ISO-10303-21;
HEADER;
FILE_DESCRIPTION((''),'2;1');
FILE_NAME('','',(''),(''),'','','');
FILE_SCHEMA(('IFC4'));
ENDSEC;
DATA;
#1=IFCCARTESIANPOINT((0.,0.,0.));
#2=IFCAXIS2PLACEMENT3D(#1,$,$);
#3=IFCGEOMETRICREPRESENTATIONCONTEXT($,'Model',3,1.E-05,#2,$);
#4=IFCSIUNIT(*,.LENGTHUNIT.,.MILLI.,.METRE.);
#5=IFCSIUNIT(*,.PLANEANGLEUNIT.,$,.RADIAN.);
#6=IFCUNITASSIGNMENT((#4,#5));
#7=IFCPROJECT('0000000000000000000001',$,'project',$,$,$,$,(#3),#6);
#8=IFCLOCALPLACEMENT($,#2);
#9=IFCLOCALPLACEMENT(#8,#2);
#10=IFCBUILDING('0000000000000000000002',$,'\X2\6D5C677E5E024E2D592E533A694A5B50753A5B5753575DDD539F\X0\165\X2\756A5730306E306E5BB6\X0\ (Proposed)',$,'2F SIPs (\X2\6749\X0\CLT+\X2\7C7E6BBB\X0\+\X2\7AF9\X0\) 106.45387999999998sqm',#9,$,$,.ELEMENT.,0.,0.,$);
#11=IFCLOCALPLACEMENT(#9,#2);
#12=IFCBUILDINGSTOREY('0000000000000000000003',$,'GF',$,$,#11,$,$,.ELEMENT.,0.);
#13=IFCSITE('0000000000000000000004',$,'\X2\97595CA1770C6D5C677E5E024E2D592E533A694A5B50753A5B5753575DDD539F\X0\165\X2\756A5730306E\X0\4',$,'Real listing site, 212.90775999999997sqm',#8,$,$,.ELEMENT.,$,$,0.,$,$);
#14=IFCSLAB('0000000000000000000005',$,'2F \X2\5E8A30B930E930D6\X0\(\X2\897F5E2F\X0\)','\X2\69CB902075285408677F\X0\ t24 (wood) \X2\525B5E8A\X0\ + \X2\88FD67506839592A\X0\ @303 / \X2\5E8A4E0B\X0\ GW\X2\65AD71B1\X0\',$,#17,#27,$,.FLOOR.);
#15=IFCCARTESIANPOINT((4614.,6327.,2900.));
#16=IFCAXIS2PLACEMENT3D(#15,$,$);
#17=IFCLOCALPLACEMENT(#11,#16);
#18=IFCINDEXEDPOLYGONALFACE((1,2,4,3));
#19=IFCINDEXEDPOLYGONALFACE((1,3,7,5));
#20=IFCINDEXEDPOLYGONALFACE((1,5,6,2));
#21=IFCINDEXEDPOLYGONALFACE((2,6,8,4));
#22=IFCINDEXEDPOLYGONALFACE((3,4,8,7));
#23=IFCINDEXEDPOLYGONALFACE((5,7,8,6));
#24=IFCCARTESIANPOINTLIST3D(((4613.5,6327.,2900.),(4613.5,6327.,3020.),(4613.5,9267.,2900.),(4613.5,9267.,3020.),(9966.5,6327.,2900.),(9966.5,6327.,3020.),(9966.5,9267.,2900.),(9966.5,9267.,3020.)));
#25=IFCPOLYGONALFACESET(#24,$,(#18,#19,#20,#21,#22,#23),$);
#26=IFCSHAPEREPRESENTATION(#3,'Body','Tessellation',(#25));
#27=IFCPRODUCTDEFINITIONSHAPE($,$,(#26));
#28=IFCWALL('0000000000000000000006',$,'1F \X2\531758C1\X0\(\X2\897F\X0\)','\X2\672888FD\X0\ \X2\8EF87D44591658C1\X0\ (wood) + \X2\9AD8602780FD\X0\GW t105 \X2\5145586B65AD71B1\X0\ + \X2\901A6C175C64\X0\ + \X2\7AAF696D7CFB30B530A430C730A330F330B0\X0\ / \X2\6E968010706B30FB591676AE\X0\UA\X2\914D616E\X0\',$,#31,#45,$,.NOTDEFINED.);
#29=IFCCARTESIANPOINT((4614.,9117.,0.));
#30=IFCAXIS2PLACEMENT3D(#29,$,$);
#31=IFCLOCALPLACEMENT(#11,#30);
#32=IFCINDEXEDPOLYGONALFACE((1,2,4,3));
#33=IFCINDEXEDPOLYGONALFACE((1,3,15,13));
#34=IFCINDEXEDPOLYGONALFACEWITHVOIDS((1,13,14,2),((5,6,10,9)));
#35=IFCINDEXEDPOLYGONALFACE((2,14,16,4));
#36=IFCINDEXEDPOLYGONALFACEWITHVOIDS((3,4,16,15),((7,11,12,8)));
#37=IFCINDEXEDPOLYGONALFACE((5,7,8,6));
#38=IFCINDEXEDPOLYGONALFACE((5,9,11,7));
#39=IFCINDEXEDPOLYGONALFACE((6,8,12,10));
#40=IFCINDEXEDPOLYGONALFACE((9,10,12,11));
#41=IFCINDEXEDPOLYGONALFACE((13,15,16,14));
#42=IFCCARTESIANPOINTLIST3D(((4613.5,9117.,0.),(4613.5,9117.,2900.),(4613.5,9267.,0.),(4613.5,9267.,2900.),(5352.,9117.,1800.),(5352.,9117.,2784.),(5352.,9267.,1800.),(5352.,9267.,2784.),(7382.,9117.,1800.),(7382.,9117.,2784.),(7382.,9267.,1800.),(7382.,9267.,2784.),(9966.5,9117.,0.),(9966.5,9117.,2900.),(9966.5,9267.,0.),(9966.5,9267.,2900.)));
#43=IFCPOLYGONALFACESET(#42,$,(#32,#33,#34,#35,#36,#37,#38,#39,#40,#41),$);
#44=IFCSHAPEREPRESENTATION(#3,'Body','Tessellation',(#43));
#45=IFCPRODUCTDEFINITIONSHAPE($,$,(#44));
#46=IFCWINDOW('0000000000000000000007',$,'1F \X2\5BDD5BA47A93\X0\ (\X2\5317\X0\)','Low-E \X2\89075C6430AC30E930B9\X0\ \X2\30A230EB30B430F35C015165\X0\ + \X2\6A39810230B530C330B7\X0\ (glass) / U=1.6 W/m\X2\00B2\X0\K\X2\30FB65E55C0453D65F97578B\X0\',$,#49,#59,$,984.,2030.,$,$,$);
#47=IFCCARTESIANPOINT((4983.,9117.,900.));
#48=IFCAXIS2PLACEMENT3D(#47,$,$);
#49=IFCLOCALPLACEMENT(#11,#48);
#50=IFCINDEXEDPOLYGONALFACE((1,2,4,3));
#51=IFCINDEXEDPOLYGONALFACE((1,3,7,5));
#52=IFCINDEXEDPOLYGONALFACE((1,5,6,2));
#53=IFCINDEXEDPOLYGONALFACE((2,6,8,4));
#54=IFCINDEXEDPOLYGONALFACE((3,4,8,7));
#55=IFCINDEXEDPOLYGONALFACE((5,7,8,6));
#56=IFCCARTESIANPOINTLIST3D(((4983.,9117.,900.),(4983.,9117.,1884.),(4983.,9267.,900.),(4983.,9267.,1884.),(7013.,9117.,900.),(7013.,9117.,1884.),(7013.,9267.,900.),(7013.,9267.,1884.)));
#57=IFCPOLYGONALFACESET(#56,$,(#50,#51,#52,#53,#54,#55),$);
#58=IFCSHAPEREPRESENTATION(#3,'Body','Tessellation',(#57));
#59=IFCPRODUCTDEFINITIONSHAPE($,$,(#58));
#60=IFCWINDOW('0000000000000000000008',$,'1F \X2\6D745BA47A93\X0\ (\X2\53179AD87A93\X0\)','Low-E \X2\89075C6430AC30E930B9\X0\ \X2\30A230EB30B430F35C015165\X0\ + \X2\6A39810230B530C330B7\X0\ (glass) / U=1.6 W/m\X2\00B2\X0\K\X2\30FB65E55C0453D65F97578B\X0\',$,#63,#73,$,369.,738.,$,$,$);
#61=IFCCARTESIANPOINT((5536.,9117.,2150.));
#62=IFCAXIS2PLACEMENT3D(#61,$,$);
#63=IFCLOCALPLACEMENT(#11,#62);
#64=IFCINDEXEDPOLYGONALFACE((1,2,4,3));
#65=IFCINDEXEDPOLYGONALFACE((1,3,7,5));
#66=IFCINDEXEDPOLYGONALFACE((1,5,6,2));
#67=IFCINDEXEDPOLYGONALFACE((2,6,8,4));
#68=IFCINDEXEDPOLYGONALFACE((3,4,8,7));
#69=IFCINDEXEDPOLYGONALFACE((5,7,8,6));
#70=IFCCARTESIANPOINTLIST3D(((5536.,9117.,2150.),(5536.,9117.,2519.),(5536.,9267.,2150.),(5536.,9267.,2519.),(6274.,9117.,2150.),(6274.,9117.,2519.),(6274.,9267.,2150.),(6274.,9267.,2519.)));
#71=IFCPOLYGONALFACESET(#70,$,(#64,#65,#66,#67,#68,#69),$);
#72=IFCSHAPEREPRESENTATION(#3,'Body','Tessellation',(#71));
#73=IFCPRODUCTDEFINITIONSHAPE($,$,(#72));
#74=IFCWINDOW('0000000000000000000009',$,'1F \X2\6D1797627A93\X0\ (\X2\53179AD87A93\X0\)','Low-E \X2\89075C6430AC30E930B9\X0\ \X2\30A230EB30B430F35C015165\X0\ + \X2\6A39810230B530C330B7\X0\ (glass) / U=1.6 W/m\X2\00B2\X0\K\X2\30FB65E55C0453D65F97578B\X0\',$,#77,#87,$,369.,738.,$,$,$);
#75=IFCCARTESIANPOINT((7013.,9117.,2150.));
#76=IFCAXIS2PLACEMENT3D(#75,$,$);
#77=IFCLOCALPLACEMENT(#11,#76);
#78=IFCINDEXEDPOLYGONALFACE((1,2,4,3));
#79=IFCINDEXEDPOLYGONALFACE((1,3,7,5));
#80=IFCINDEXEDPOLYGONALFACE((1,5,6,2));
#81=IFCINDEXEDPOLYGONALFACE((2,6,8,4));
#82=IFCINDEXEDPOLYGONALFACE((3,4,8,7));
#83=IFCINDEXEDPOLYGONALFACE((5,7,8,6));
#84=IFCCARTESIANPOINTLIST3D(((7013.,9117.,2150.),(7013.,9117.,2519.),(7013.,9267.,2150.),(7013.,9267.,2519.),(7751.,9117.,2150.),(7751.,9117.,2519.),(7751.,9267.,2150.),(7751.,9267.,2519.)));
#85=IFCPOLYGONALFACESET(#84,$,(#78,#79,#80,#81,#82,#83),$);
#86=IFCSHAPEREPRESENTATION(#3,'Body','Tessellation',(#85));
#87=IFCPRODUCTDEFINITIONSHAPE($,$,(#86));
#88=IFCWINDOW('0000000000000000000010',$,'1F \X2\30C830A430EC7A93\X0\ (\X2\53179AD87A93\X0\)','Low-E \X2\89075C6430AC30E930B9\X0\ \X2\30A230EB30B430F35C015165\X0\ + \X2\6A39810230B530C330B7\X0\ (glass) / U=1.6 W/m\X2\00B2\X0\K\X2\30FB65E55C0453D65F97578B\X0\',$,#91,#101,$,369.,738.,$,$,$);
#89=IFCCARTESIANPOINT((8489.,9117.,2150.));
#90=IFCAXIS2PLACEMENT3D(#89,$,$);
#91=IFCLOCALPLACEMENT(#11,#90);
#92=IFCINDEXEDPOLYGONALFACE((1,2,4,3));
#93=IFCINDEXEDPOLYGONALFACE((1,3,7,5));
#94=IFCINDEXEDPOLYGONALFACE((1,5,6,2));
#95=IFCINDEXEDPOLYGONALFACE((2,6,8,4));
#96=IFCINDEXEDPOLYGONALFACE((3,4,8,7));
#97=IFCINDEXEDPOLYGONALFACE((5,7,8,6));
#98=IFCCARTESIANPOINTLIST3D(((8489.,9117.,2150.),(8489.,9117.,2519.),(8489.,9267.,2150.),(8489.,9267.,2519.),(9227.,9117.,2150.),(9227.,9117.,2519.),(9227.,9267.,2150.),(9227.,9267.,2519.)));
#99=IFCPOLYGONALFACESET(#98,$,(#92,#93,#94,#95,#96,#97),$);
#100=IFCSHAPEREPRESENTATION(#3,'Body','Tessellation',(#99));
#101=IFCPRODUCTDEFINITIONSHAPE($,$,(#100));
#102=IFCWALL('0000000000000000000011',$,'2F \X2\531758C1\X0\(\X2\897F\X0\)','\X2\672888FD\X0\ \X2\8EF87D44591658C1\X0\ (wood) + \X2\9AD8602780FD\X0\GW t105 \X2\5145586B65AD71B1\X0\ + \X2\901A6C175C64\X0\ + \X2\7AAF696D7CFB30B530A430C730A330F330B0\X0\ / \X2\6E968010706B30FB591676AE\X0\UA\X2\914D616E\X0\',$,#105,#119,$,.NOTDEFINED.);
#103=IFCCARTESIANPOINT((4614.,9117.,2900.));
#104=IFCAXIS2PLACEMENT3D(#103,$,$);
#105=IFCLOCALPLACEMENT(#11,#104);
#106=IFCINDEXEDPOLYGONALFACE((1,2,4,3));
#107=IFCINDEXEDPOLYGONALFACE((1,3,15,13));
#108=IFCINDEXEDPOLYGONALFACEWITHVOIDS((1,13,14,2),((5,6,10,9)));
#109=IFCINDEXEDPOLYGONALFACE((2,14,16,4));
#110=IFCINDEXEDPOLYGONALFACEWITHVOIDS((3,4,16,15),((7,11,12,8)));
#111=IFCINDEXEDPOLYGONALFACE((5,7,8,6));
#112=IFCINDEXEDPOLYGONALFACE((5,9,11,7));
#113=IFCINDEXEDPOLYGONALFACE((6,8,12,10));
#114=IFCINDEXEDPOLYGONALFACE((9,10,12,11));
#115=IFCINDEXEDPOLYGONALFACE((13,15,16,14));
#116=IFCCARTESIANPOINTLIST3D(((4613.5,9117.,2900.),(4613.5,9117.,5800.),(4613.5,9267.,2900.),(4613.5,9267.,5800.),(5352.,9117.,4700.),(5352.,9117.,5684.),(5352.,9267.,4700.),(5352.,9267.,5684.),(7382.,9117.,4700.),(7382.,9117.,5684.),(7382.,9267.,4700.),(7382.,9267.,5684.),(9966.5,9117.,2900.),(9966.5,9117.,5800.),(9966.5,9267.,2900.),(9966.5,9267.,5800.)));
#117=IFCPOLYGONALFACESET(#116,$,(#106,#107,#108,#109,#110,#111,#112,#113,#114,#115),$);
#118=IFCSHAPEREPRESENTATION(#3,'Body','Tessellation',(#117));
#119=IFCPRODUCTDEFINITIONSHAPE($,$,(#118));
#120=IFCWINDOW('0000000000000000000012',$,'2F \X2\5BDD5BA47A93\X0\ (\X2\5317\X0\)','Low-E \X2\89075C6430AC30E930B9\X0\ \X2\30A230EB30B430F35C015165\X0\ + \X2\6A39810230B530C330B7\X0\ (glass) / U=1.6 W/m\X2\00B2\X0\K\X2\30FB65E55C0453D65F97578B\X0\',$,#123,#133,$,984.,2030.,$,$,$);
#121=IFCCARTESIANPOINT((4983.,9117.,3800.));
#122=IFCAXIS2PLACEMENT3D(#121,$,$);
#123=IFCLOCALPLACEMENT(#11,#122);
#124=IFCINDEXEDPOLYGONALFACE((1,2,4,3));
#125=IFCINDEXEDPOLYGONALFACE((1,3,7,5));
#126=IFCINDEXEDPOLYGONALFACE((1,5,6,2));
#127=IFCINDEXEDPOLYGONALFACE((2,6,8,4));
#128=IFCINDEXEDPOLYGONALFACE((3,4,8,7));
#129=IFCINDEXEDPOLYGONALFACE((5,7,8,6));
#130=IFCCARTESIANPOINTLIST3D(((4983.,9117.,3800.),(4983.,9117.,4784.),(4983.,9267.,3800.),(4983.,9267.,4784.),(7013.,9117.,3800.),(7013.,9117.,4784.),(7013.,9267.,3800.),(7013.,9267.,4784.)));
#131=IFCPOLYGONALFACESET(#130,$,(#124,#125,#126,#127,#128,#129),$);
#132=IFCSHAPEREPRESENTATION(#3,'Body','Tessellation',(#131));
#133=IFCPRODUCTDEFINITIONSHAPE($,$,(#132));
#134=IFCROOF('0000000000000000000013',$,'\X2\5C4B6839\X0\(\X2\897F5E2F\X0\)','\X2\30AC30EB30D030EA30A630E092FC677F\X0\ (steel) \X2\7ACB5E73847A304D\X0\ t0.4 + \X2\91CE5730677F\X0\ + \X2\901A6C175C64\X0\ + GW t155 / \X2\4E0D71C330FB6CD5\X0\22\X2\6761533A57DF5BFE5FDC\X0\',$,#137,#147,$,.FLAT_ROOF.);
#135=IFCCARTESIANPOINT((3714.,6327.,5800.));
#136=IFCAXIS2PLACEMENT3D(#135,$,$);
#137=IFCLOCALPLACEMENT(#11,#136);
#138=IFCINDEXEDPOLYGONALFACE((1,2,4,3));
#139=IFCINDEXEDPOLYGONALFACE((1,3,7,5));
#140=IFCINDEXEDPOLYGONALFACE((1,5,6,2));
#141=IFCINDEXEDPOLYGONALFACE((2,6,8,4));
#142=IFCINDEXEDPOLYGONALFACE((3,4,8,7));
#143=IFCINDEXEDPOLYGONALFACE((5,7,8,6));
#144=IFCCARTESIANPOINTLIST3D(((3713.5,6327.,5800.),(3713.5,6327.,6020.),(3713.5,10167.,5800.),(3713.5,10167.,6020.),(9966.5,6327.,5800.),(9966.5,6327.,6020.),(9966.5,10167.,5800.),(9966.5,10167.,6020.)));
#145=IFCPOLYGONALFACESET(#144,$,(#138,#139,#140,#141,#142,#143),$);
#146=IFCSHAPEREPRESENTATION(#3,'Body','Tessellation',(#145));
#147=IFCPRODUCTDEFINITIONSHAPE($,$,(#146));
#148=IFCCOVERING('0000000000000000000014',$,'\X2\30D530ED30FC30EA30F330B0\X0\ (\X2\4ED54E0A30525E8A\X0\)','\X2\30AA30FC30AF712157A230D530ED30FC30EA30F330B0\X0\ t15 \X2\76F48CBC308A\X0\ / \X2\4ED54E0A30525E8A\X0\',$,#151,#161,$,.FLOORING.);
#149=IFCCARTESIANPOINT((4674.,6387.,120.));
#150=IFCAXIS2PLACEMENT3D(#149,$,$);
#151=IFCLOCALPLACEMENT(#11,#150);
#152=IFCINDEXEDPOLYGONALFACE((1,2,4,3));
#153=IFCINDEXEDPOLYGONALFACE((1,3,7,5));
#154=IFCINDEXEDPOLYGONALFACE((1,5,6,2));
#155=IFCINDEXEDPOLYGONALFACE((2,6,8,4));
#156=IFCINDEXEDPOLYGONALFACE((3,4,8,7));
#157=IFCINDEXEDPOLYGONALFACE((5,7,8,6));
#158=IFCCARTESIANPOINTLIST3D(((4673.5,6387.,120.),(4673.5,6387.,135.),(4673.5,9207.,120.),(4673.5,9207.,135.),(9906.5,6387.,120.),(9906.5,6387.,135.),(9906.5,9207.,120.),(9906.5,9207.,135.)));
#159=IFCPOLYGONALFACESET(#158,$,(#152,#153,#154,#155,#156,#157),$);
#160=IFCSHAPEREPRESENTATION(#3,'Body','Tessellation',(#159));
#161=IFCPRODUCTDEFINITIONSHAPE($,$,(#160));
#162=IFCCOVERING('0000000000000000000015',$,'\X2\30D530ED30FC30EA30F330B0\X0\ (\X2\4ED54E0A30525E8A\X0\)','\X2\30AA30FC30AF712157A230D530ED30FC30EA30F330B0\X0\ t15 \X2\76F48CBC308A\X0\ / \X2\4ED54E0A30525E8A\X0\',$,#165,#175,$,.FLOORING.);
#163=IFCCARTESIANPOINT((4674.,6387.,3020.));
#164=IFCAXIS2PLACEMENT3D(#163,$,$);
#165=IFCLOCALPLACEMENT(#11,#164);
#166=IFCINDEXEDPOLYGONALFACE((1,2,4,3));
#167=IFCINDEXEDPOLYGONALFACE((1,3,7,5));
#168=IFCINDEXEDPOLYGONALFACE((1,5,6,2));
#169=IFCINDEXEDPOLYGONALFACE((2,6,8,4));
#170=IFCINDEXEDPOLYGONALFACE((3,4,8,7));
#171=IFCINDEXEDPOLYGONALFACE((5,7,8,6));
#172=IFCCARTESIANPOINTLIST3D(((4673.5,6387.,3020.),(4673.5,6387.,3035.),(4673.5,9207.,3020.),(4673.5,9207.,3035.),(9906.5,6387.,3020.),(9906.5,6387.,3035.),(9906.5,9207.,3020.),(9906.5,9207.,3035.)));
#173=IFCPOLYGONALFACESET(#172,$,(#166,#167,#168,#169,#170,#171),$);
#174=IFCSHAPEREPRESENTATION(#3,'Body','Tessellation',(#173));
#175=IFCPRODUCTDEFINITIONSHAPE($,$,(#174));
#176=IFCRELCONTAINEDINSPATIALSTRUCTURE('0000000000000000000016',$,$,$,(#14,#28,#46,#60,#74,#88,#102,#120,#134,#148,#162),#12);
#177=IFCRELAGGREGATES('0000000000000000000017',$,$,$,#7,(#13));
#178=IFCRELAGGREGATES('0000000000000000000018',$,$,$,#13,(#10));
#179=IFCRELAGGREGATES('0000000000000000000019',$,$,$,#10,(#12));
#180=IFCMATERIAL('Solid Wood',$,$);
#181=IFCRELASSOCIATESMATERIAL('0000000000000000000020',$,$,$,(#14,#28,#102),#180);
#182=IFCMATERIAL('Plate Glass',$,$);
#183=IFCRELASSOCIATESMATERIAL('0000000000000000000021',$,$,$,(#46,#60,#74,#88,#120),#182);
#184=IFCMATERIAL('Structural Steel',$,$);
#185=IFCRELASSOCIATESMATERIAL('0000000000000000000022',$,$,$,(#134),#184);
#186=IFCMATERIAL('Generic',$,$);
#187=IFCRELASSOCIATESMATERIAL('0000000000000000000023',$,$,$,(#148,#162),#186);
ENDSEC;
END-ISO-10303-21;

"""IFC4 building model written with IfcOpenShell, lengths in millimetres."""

from ifc_helpers import new_model, si_unit, frame, frame_2d, origin, place, context, project, spatial, rectangle, extrude, material, element, fill, save


model = new_model("IFC4")

# Units and contexts
model_context = context("Model", 3, precision=1e-05, world=origin())
ifc_project = project(units=[si_unit("LENGTHUNIT", "METRE", prefix="MILLI"), si_unit("PLANEANGLEUNIT", "RADIAN")], contexts=[model_context])

# Site, building, storey
site_placement = place(None, origin())
site = spatial("IfcSite", under=ifc_project, at=site_placement, Name="静岡県浜松市中央区楊子町字南川原165番地の4", ObjectType="Real listing site, 212.90775999999997sqm", CompositionType="ELEMENT", RefElevation=0.0)
building_placement = place(site_placement, origin())
building = spatial("IfcBuilding", under=site, at=building_placement, Name="浜松市中央区楊子町字南川原165番地のの家 (Proposed)", ObjectType="2F SIPs (杉CLT+籾殻+竹) 106.45387999999998sqm", CompositionType="ELEMENT", ElevationOfRefHeight=0.0, ElevationOfTerrain=0.0)
storey_placement = place(building_placement, origin())
storey = spatial("IfcBuildingStorey", under=building, at=storey_placement, Name="GF", CompositionType="ELEMENT", Elevation=0.0)

# Slab
ifc_material_1 = material(Name="Solid Wood")
slab_1_placement = place(storey_placement, frame((4614.0, 6327.0, 2900.0)))
element("IfcSlab", 1, at=slab_1_placement, inside=storey, material=ifc_material_1, Name="2F 床スラブ(西帯)", Description="構造用合板 t24 (wood) 剛床 + 製材根太 @303 / 床下 GW断熱", PredefinedType="FLOOR", context=model_context, shape_type="SweptSolid", body=[
    extrude(rectangle(XDim=5353.0, YDim=2940.0, at=frame_2d((2676.0, 1470.0))), frame((4614.0, 6327.0, 2900.0)), (0.0, 0.0, 1.0), 120.0),
])

# Wall, openings, windows
wall_1_placement = place(storey_placement, frame((4614.0, 9117.0, 0.0)))
wall_1 = element("IfcWall", 2, at=wall_1_placement, inside=storey, material=ifc_material_1, Name="1F 北壁(西)", Description="木製 軸組外壁 (wood) + 高性能GW t105 充填断熱 + 通気層 + 窯業系サイディング / 準耐火・外皮UA配慮", PredefinedType="NOTDEFINED", context=model_context, shape_type="SweptSolid", body=[
    extrude(rectangle(XDim=5353.0, YDim=150.0, at=frame_2d((2676.0, 75.0))), frame((4614.0, 9117.0, 0.0)), (0.0, 0.0, 1.0), 2900.0),
])
opening_1_placement = place(storey_placement, frame((4983.0, 9117.0, 900.0)))
opening_1 = element("IfcOpeningElement", 3, at=opening_1_placement, cuts=wall_1, PredefinedType="NOTDEFINED", context=model_context, shape_type="SweptSolid", body=[
    extrude(rectangle(XDim=2030.0, YDim=150.0, at=frame_2d((1015.0, 75.0))), frame((4983.0, 9117.0, 900.0)), (0.0, 0.0, 1.0), 984.0),
])
opening_2_placement = place(storey_placement, frame((5536.0, 9117.0, 2150.0)))
opening_2 = element("IfcOpeningElement", 4, at=opening_2_placement, cuts=wall_1, PredefinedType="NOTDEFINED", context=model_context, shape_type="SweptSolid", body=[
    extrude(rectangle(XDim=738.0, YDim=150.0, at=frame_2d((369.0, 75.0))), frame((5536.0, 9117.0, 2150.0)), (0.0, 0.0, 1.0), 369.0),
])
opening_3_placement = place(storey_placement, frame((7013.0, 9117.0, 2150.0)))
opening_3 = element("IfcOpeningElement", 5, at=opening_3_placement, cuts=wall_1, PredefinedType="NOTDEFINED", context=model_context, shape_type="SweptSolid", body=[
    extrude(rectangle(XDim=738.0, YDim=150.0, at=frame_2d((369.0, 75.0))), frame((7013.0, 9117.0, 2150.0)), (0.0, 0.0, 1.0), 369.0),
])
opening_4_placement = place(storey_placement, frame((8489.0, 9117.0, 2150.0)))
opening_4 = element("IfcOpeningElement", 6, at=opening_4_placement, cuts=wall_1, PredefinedType="NOTDEFINED", context=model_context, shape_type="SweptSolid", body=[
    extrude(rectangle(XDim=738.0, YDim=150.0, at=frame_2d((369.0, 75.0))), frame((8489.0, 9117.0, 2150.0)), (0.0, 0.0, 1.0), 369.0),
])
ifc_material_2 = material(Name="Plate Glass")
window_1_placement = place(storey_placement, frame((4983.0, 9117.0, 900.0)))
window_1 = element("IfcWindow", 7, at=window_1_placement, inside=storey, material=ifc_material_2, Name="1F 寝室窓 (北)", Description="Low-E 複層ガラス アルゴン封入 + 樹脂サッシ (glass) / U=1.6 W/m²K・日射取得型", OverallHeight=984.0, OverallWidth=2030.0, context=model_context, shape_type="SweptSolid", body=[
    extrude(rectangle(XDim=2030.0, YDim=150.0, at=frame_2d((1015.0, 75.0))), frame((4983.0, 9117.0, 900.0)), (0.0, 0.0, 1.0), 984.0),
])
fill(opening_1, window_1)
window_2_placement = place(storey_placement, frame((5536.0, 9117.0, 2150.0)))
window_2 = element("IfcWindow", 8, at=window_2_placement, inside=storey, material=ifc_material_2, Name="1F 浴室窓 (北高窓)", Description="Low-E 複層ガラス アルゴン封入 + 樹脂サッシ (glass) / U=1.6 W/m²K・日射取得型", OverallHeight=369.0, OverallWidth=738.0, context=model_context, shape_type="SweptSolid", body=[
    extrude(rectangle(XDim=738.0, YDim=150.0, at=frame_2d((369.0, 75.0))), frame((5536.0, 9117.0, 2150.0)), (0.0, 0.0, 1.0), 369.0),
])
fill(opening_2, window_2)
window_3_placement = place(storey_placement, frame((7013.0, 9117.0, 2150.0)))
window_3 = element("IfcWindow", 9, at=window_3_placement, inside=storey, material=ifc_material_2, Name="1F 洗面窓 (北高窓)", Description="Low-E 複層ガラス アルゴン封入 + 樹脂サッシ (glass) / U=1.6 W/m²K・日射取得型", OverallHeight=369.0, OverallWidth=738.0, context=model_context, shape_type="SweptSolid", body=[
    extrude(rectangle(XDim=738.0, YDim=150.0, at=frame_2d((369.0, 75.0))), frame((7013.0, 9117.0, 2150.0)), (0.0, 0.0, 1.0), 369.0),
])
fill(opening_3, window_3)
window_4_placement = place(storey_placement, frame((8489.0, 9117.0, 2150.0)))
window_4 = element("IfcWindow", 10, at=window_4_placement, inside=storey, material=ifc_material_2, Name="1F トイレ窓 (北高窓)", Description="Low-E 複層ガラス アルゴン封入 + 樹脂サッシ (glass) / U=1.6 W/m²K・日射取得型", OverallHeight=369.0, OverallWidth=738.0, context=model_context, shape_type="SweptSolid", body=[
    extrude(rectangle(XDim=738.0, YDim=150.0, at=frame_2d((369.0, 75.0))), frame((8489.0, 9117.0, 2150.0)), (0.0, 0.0, 1.0), 369.0),
])
fill(opening_4, window_4)

# Wall, opening, window
wall_2_placement = place(storey_placement, frame((4614.0, 9117.0, 2900.0)))
wall_2 = element("IfcWall", 11, at=wall_2_placement, inside=storey, material=ifc_material_1, Name="2F 北壁(西)", Description="木製 軸組外壁 (wood) + 高性能GW t105 充填断熱 + 通気層 + 窯業系サイディング / 準耐火・外皮UA配慮", PredefinedType="NOTDEFINED", context=model_context, shape_type="SweptSolid", body=[
    extrude(rectangle(XDim=5353.0, YDim=150.0, at=frame_2d((2676.0, 75.0))), frame((4614.0, 9117.0, 2900.0)), (0.0, 0.0, 1.0), 2900.0),
])
opening_5_placement = place(storey_placement, frame((4983.0, 9117.0, 3800.0)))
opening_5 = element("IfcOpeningElement", 12, at=opening_5_placement, cuts=wall_2, PredefinedType="NOTDEFINED", context=model_context, shape_type="SweptSolid", body=[
    extrude(rectangle(XDim=2030.0, YDim=150.0, at=frame_2d((1015.0, 75.0))), frame((4983.0, 9117.0, 3800.0)), (0.0, 0.0, 1.0), 984.0),
])
window_5_placement = place(storey_placement, frame((4983.0, 9117.0, 3800.0)))
window_5 = element("IfcWindow", 13, at=window_5_placement, inside=storey, material=ifc_material_2, Name="2F 寝室窓 (北)", Description="Low-E 複層ガラス アルゴン封入 + 樹脂サッシ (glass) / U=1.6 W/m²K・日射取得型", OverallHeight=984.0, OverallWidth=2030.0, context=model_context, shape_type="SweptSolid", body=[
    extrude(rectangle(XDim=2030.0, YDim=150.0, at=frame_2d((1015.0, 75.0))), frame((4983.0, 9117.0, 3800.0)), (0.0, 0.0, 1.0), 984.0),
])
fill(opening_5, window_5)

# Roof
ifc_material_3 = material(Name="Structural Steel")
for number, where, name in (
    (14, (3714.0, 6327.0, 5800.0), "屋根(西帯)"),
):
    element("IfcRoof", number, at=place(storey_placement, frame(where)), inside=storey, material=ifc_material_3, Name=name, Description="ガルバリウム鋼板 (steel) 立平葺き t0.4 + 野地板 + 通気層 + GW t155 / 不燃・法22条区域対応", PredefinedType="FLAT_ROOF", context=model_context, shape_type="SweptSolid", body=[
        extrude(rectangle(XDim=6253.0, YDim=3840.0, at=frame_2d((3126.0, 1920.0))), frame((3714.0, 6327.0, 5800.0)), (0.0, 0.0, 1.0), 220.0),
    ])

# Coverings
ifc_material_4 = material(Name="Generic")
covering_1_placement = place(storey_placement, frame((4674.0, 6387.0, 120.0)))
element("IfcCovering", 15, at=covering_1_placement, inside=storey, material=ifc_material_4, Name="フローリング (仕上げ床)", Description="オーク無垢フローリング t15 直貼り / 仕上げ床", PredefinedType="FLOORING", context=model_context, shape_type="SweptSolid", body=[
    extrude(rectangle(XDim=5233.0, YDim=2820.0, at=frame_2d((2616.0, 1410.0))), frame((4674.0, 6387.0, 120.0)), (0.0, 0.0, 1.0), 15.0),
])
covering_2_placement = place(storey_placement, frame((4674.0, 6387.0, 3020.0)))
element("IfcCovering", 16, at=covering_2_placement, inside=storey, material=ifc_material_4, Name="フローリング (仕上げ床)", Description="オーク無垢フローリング t15 直貼り / 仕上げ床", PredefinedType="FLOORING", context=model_context, shape_type="SweptSolid", body=[
    extrude(rectangle(XDim=5233.0, YDim=2820.0, at=frame_2d((2616.0, 1410.0))), frame((4674.0, 6387.0, 3020.0)), (0.0, 0.0, 1.0), 15.0),
])

save(model, "model.ifc")
